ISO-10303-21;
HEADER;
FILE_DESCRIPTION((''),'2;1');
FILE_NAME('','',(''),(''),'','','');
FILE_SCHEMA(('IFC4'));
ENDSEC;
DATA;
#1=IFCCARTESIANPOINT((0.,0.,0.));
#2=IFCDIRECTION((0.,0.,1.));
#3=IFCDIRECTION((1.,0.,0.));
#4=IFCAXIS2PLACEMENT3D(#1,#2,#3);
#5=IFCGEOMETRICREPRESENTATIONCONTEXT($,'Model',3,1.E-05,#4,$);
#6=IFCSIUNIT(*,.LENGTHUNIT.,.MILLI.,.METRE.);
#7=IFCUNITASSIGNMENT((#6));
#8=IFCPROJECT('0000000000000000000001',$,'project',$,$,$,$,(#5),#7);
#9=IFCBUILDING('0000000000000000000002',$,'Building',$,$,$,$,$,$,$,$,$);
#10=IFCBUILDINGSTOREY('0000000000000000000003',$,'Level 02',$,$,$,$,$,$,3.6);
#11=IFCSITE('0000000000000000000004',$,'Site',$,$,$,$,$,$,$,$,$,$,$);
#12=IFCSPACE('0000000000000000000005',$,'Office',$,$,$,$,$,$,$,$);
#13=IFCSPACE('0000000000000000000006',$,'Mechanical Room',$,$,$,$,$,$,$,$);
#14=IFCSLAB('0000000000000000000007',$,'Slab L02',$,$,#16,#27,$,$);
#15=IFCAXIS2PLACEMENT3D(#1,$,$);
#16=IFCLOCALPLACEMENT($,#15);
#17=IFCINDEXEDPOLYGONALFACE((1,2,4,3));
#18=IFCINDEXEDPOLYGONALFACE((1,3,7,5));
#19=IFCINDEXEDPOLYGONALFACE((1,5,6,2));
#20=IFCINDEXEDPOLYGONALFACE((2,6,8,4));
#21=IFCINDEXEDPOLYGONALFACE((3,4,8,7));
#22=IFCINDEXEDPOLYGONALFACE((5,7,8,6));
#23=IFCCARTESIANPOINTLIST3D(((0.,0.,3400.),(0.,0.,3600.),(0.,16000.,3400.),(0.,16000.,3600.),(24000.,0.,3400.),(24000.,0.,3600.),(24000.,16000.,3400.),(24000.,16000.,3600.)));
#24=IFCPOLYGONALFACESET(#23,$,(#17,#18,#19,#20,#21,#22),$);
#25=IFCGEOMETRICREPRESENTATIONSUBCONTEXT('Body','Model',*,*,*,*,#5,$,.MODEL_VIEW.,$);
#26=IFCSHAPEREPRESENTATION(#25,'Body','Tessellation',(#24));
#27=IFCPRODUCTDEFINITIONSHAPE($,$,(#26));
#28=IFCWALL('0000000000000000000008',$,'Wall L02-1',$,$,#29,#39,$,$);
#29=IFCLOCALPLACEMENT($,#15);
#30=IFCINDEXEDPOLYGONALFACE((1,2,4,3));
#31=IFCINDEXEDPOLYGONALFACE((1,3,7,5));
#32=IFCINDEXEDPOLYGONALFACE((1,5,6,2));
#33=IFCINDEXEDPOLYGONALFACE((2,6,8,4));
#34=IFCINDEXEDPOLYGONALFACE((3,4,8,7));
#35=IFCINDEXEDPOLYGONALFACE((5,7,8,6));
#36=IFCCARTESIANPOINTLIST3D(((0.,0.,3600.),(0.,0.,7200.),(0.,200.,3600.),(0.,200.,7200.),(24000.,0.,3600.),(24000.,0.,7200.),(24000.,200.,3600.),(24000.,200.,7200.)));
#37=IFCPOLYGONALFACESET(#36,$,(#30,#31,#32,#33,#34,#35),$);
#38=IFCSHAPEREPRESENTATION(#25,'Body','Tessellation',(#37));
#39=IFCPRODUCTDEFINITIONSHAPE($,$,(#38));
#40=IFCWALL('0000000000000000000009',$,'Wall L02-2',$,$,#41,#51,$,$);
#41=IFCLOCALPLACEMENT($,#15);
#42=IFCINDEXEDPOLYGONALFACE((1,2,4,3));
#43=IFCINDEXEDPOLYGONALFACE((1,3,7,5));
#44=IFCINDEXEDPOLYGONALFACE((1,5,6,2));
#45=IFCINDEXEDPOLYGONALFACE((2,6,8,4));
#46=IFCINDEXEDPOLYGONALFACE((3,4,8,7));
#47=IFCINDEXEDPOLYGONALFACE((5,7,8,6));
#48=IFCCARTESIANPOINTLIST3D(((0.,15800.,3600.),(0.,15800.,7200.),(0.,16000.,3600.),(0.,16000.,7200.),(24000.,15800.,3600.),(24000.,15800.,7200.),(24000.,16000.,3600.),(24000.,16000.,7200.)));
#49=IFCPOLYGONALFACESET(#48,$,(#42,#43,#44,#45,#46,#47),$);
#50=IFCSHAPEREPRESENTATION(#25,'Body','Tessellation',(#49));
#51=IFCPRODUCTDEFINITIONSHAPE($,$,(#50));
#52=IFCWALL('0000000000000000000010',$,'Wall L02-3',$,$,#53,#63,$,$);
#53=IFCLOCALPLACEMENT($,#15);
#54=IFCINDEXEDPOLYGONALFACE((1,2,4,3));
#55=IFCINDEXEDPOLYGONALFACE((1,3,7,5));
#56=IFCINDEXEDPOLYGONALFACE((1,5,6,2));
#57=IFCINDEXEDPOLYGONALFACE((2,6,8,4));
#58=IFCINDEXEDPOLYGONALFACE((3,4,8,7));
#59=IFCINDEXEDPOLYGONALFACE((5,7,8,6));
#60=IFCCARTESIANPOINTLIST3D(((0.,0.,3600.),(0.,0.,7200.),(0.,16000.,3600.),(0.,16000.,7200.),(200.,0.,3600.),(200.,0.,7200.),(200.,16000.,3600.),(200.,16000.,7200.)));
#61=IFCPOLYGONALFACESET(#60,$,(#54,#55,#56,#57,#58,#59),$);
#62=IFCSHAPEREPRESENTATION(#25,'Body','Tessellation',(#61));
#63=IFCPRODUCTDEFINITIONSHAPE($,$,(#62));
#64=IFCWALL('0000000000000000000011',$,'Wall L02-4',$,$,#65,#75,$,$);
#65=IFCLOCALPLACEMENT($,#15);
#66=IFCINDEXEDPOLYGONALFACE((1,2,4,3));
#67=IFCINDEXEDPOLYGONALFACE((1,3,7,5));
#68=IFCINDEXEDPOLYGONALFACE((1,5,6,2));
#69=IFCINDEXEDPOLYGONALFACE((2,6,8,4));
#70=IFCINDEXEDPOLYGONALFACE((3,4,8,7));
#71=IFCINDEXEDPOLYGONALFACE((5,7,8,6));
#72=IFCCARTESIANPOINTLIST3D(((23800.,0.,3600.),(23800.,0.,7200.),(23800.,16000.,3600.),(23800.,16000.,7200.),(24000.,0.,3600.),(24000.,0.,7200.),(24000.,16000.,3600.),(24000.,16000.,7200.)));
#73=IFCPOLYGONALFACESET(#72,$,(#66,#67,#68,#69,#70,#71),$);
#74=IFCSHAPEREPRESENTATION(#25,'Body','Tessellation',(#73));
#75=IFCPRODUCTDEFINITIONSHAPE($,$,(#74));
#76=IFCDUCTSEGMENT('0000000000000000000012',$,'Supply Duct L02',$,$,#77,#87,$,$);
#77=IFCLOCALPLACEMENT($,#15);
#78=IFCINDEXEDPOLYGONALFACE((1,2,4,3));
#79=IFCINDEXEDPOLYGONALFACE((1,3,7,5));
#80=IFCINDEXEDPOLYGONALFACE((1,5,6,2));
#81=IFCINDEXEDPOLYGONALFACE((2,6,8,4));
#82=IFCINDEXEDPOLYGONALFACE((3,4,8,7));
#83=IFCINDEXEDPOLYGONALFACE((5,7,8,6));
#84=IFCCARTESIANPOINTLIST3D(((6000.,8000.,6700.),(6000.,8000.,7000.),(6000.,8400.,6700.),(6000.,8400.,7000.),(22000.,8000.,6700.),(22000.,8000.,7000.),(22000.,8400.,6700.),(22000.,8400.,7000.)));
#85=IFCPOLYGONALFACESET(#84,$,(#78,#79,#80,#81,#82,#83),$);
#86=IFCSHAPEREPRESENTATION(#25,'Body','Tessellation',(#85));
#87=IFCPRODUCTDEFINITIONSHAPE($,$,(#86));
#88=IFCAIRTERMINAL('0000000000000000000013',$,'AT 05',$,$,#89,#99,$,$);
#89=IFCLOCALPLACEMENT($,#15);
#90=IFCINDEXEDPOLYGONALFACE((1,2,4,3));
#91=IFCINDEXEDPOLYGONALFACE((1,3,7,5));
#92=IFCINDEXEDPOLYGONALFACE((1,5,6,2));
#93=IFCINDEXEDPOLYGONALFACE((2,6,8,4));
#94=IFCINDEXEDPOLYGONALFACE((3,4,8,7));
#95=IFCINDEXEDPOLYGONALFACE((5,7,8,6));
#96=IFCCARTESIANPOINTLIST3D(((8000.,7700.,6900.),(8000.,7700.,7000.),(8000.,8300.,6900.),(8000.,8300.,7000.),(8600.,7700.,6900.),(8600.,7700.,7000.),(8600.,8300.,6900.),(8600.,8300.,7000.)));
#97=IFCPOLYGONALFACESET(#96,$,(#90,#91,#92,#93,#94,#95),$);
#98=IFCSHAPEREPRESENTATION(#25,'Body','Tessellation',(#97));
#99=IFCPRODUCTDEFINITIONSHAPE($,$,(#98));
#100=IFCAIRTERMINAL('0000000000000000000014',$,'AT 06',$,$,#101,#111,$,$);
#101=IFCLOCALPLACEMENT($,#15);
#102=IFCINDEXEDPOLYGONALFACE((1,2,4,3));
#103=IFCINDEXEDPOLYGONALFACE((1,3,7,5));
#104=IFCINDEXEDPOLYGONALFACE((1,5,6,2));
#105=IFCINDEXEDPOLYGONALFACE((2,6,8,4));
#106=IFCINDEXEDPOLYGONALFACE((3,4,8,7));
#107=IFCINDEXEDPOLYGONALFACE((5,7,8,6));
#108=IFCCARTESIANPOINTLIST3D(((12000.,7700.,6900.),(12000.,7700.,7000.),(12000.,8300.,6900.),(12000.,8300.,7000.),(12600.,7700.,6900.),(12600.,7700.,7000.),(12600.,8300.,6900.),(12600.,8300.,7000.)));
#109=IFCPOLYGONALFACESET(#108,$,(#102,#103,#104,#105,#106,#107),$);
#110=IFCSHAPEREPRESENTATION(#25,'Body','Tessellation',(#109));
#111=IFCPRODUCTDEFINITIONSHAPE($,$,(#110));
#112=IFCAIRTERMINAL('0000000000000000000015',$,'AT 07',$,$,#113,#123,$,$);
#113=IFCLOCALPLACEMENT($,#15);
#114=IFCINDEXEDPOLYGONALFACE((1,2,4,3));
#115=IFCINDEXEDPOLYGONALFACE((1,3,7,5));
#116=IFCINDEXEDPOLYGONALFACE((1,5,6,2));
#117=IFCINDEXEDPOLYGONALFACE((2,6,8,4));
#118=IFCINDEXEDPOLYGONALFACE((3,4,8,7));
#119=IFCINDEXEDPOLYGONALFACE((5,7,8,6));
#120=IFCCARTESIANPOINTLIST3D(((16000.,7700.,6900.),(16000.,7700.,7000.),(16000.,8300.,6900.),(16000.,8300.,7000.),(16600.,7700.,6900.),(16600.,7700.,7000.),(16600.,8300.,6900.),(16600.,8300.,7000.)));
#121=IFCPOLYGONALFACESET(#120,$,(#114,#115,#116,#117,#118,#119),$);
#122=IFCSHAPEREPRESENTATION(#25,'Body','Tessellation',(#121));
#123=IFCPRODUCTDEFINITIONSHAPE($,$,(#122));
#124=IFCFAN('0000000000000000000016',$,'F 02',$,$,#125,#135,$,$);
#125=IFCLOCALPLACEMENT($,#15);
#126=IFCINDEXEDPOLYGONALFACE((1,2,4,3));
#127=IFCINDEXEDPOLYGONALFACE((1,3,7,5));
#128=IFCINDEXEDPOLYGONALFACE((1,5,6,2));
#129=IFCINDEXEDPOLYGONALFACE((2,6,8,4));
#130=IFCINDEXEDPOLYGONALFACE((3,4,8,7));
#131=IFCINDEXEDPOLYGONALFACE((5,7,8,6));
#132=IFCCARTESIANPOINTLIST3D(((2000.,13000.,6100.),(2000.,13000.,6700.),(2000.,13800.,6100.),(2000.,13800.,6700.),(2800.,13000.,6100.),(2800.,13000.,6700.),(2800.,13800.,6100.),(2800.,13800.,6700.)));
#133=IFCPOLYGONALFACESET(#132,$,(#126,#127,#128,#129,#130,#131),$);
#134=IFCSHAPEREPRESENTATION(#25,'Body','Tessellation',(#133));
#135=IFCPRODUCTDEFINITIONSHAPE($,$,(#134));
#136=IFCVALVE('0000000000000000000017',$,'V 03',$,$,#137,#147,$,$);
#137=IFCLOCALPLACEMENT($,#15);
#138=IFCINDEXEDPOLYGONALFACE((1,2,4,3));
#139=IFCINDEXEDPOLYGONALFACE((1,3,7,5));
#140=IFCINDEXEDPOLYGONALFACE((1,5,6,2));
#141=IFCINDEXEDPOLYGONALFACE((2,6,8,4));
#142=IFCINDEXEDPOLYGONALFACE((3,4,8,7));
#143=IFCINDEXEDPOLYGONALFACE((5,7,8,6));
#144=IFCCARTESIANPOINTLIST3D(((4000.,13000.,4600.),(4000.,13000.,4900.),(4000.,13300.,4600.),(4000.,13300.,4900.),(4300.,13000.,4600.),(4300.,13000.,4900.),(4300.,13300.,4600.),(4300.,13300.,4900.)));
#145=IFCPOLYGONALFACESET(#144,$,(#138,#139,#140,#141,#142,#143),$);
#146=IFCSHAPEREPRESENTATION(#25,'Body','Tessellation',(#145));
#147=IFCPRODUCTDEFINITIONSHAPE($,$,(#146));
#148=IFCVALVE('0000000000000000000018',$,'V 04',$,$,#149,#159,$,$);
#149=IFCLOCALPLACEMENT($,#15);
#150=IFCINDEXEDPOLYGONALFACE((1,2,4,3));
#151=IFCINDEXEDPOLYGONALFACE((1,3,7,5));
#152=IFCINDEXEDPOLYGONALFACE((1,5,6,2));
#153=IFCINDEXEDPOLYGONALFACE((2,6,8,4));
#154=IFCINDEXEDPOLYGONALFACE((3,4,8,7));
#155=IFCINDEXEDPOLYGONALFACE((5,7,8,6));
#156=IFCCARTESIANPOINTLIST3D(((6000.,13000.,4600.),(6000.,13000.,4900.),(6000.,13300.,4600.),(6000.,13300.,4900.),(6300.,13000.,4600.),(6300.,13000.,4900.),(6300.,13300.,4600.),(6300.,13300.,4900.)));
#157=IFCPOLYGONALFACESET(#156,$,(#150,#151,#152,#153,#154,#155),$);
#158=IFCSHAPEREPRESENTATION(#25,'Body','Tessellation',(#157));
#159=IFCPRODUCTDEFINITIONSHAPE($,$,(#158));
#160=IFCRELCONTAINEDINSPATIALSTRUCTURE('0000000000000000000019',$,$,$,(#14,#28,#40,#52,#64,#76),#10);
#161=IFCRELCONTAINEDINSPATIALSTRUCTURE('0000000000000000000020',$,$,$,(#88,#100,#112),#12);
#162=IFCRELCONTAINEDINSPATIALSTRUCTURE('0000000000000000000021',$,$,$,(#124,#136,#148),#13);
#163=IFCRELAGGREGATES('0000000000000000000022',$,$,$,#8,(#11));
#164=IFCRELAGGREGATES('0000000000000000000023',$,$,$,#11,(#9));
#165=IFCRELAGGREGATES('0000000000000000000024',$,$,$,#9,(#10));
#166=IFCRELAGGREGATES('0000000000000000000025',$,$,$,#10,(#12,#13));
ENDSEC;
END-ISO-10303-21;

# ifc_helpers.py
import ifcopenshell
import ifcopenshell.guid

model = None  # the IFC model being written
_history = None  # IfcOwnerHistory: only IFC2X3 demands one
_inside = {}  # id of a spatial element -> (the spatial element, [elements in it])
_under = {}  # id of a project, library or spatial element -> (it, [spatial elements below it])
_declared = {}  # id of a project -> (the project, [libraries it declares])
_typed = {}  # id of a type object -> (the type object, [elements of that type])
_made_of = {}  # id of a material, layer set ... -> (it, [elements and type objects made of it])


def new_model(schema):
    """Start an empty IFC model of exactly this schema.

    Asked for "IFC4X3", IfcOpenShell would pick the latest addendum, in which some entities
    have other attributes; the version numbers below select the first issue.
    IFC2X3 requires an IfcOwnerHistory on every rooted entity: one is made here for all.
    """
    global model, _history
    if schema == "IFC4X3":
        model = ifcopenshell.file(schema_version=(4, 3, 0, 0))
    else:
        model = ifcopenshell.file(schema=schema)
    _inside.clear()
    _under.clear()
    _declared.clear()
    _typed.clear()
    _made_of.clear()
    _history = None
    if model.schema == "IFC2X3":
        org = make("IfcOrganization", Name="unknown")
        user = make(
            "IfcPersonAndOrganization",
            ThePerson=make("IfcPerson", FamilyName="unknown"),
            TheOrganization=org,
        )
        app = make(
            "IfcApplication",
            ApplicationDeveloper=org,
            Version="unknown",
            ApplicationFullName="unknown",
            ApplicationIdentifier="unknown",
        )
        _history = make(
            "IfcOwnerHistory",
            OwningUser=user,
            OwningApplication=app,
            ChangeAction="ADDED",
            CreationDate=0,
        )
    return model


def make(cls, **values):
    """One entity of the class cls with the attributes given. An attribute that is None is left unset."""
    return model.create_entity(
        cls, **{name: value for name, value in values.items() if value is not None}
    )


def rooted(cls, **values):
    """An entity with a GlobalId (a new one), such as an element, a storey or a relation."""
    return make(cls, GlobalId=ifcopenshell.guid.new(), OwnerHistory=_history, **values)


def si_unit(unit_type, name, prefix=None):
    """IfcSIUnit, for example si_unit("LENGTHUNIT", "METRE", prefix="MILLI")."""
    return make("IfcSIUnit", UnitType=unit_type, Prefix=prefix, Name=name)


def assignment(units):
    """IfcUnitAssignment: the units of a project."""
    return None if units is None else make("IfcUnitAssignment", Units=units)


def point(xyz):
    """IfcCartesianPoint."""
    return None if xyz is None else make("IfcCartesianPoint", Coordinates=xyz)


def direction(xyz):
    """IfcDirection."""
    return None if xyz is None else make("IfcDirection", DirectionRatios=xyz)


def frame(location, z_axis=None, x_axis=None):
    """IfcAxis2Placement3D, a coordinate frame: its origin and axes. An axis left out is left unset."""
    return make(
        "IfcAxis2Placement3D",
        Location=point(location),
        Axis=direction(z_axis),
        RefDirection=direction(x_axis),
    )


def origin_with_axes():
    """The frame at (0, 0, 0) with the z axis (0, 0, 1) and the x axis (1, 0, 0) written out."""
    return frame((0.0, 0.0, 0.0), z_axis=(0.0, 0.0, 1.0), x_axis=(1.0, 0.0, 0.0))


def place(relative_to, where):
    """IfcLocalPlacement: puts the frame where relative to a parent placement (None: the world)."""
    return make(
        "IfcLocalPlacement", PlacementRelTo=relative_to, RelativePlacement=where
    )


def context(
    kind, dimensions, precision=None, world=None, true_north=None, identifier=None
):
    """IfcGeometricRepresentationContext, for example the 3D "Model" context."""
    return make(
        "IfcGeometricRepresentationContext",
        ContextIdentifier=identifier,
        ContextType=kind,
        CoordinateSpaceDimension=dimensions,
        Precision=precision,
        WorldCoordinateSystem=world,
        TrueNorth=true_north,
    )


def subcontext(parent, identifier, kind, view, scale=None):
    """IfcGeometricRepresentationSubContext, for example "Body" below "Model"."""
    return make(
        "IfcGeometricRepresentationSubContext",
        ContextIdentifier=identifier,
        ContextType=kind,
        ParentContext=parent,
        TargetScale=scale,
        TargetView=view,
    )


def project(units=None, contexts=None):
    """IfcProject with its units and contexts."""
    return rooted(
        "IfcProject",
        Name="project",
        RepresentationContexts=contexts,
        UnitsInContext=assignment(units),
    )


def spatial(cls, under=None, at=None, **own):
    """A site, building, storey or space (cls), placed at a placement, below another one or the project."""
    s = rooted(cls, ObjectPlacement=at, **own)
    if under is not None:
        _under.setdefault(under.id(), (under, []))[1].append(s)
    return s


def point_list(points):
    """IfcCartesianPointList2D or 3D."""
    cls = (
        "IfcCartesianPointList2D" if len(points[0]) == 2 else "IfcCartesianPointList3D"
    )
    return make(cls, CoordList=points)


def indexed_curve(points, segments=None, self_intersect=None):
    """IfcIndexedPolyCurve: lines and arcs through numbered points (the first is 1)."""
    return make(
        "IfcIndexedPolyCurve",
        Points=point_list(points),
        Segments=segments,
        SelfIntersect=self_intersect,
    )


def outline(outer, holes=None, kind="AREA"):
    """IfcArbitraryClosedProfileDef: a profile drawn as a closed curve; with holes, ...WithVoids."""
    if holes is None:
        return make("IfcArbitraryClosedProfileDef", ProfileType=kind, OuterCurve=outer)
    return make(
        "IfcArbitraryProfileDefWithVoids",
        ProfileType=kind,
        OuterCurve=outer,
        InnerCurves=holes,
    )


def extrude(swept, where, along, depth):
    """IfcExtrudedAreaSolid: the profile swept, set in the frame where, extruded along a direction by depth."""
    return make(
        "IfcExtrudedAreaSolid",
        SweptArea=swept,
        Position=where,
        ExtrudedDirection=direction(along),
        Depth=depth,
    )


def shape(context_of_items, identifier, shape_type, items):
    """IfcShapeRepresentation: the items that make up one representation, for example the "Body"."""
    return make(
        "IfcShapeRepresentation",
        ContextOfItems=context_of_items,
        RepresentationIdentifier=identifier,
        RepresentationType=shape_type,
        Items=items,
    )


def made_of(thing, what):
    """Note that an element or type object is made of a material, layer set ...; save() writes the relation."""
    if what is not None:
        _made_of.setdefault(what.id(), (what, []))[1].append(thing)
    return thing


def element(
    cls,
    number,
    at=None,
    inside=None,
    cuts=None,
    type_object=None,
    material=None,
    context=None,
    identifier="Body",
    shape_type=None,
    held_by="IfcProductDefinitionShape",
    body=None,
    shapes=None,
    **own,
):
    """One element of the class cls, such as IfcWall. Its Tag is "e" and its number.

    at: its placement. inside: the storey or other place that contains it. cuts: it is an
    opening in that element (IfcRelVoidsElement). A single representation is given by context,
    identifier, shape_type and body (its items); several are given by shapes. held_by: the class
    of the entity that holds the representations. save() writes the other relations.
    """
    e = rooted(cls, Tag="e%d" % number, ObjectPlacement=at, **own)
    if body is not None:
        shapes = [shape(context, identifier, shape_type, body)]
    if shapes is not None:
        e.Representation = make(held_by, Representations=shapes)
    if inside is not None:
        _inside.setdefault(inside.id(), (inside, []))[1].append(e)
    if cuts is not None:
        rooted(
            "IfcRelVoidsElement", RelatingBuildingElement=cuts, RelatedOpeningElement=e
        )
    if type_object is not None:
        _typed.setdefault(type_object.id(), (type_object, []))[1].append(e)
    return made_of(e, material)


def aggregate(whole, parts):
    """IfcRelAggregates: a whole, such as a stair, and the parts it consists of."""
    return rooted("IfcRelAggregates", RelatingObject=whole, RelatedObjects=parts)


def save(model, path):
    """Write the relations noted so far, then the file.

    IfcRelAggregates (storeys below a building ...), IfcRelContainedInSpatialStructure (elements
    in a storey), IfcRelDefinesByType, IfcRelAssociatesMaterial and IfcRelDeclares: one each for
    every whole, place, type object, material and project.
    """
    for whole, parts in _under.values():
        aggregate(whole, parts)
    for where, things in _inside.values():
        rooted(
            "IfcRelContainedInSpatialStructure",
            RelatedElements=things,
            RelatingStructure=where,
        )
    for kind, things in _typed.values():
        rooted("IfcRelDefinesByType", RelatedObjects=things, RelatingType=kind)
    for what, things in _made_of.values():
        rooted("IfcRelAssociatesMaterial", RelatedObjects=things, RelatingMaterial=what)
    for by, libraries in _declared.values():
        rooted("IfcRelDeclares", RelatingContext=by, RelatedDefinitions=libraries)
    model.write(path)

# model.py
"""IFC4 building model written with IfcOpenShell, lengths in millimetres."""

from ifc_helpers import new_model, si_unit, frame, origin_with_axes, place, context, subcontext, project, spatial, indexed_curve, outline, extrude, element, save


model = new_model("IFC4")

# Units and contexts
model_context = context("Model", 3, precision=1e-05, world=origin_with_axes())
body_context = subcontext(model_context, "Body", "Model", "MODEL_VIEW")
ifc_project = project(units=[si_unit("LENGTHUNIT", "METRE", prefix="MILLI")], contexts=[model_context])

# Site, building, storey
site = spatial("IfcSite", under=ifc_project, Name="Site")
building = spatial("IfcBuilding", under=site, Name="Building")
storey = spatial("IfcBuildingStorey", under=building, Name="Level 02", Elevation=3.6)

# Slab
slab_placement = place(None, frame((0.0, 0.0, 3400.0), z_axis=(0.0, 0.0, 1.0), x_axis=(1.0, 0.0, 0.0)))
element("IfcSlab", 1, at=slab_placement, inside=storey, Name="Slab L02", context=body_context, shape_type="SweptSolid", body=[
    extrude(outline(indexed_curve([(0.0, 0.0), (0.0, 16000.0), (24000.0, 16000.0), (24000.0, 0.0), (0.0, 0.0)], self_intersect=False)), origin_with_axes(), (0.0, 0.0, 1.0), 200.0),
])

# Walls
for number, where, z_axis, x_axis, name in (
    (2, (0.0, 0.0, 3600.0), (0.0, 0.0, 1.0), (1.0, 0.0, 0.0), "Wall L02-1"),
    (3, (0.0, 15800.0, 3600.0), (0.0, 0.0, 1.0), (1.0, 0.0, 0.0), "Wall L02-2"),
):
    element("IfcWall", number, at=place(None, frame(where, z_axis=z_axis, x_axis=x_axis)), inside=storey, Name=name, context=body_context, shape_type="SweptSolid", body=[
        extrude(outline(indexed_curve([(0.0, 0.0), (0.0, 200.0), (24000.0, 200.0), (24000.0, 0.0), (0.0, 0.0)], self_intersect=False)), origin_with_axes(), (0.0, 0.0, 1.0), 3600.0),
    ])
for number, where, z_axis, x_axis, name in (
    (4, (0.0, 0.0, 3600.0), (0.0, 0.0, 1.0), (1.0, 0.0, 0.0), "Wall L02-3"),
    (5, (23800.0, 0.0, 3600.0), (0.0, 0.0, 1.0), (1.0, 0.0, 0.0), "Wall L02-4"),
):
    element("IfcWall", number, at=place(None, frame(where, z_axis=z_axis, x_axis=x_axis)), inside=storey, Name=name, context=body_context, shape_type="SweptSolid", body=[
        extrude(outline(indexed_curve([(0.0, 0.0), (0.0, 16000.0), (200.0, 16000.0), (200.0, 0.0), (0.0, 0.0)], self_intersect=False)), origin_with_axes(), (0.0, 0.0, 1.0), 3600.0),
    ])

# Duct segment
duct_segment_placement = place(None, frame((6000.0, 8000.0, 6700.0), z_axis=(0.0, 0.0, 1.0), x_axis=(1.0, 0.0, 0.0)))
element("IfcDuctSegment", 6, at=duct_segment_placement, inside=storey, Name="Supply Duct L02", context=body_context, shape_type="SweptSolid", body=[
    extrude(outline(indexed_curve([(0.0, 0.0), (0.0, 400.0), (16000.0, 400.0), (16000.0, 0.0), (0.0, 0.0)], self_intersect=False)), origin_with_axes(), (0.0, 0.0, 1.0), 300.0),
])

# Shared definitions
space_1 = spatial("IfcSpace", under=storey, Name="Office")

# Air terminals
for number, where, z_axis, x_axis, name in (
    (7, (8000.0, 7700.0, 6900.0), (0.0, 0.0, 1.0), (1.0, 0.0, 0.0), "AT 05"),
    (8, (12000.0, 7700.0, 6900.0), (0.0, 0.0, 1.0), (1.0, 0.0, 0.0), "AT 06"),
    (9, (16000.0, 7700.0, 6900.0), (0.0, 0.0, 1.0), (1.0, 0.0, 0.0), "AT 07"),
):
    element("IfcAirTerminal", number, at=place(None, frame(where, z_axis=z_axis, x_axis=x_axis)), inside=space_1, Name=name, context=body_context, shape_type="SweptSolid", body=[
        extrude(outline(indexed_curve([(0.0, 0.0), (0.0, 600.0), (600.0, 600.0), (600.0, 0.0), (0.0, 0.0)], self_intersect=False)), origin_with_axes(), (0.0, 0.0, 1.0), 100.0),
    ])

# Shared definitions
space_2 = spatial("IfcSpace", under=storey, Name="Mechanical Room")

# Fan
fan_placement = place(None, frame((2000.0, 13000.0, 6100.0), z_axis=(0.0, 0.0, 1.0), x_axis=(1.0, 0.0, 0.0)))
element("IfcFan", 10, at=fan_placement, inside=space_2, Name="F 02", context=body_context, shape_type="SweptSolid", body=[
    extrude(outline(indexed_curve([(0.0, 0.0), (0.0, 800.0), (800.0, 800.0), (800.0, 0.0), (0.0, 0.0)], self_intersect=False)), origin_with_axes(), (0.0, 0.0, 1.0), 600.0),
])

# Valves
for number, where, z_axis, x_axis, name in (
    (11, (4000.0, 13000.0, 4600.0), (0.0, 0.0, 1.0), (1.0, 0.0, 0.0), "V 03"),
    (12, (6000.0, 13000.0, 4600.0), (0.0, 0.0, 1.0), (1.0, 0.0, 0.0), "V 04"),
):
    element("IfcValve", number, at=place(None, frame(where, z_axis=z_axis, x_axis=x_axis)), inside=space_2, Name=name, context=body_context, shape_type="SweptSolid", body=[
        extrude(outline(indexed_curve([(0.0, 0.0), (0.0, 300.0), (300.0, 300.0), (300.0, 0.0), (0.0, 0.0)], self_intersect=False)), origin_with_axes(), (0.0, 0.0, 1.0), 300.0),
    ])

save(model, "model.ifc")
